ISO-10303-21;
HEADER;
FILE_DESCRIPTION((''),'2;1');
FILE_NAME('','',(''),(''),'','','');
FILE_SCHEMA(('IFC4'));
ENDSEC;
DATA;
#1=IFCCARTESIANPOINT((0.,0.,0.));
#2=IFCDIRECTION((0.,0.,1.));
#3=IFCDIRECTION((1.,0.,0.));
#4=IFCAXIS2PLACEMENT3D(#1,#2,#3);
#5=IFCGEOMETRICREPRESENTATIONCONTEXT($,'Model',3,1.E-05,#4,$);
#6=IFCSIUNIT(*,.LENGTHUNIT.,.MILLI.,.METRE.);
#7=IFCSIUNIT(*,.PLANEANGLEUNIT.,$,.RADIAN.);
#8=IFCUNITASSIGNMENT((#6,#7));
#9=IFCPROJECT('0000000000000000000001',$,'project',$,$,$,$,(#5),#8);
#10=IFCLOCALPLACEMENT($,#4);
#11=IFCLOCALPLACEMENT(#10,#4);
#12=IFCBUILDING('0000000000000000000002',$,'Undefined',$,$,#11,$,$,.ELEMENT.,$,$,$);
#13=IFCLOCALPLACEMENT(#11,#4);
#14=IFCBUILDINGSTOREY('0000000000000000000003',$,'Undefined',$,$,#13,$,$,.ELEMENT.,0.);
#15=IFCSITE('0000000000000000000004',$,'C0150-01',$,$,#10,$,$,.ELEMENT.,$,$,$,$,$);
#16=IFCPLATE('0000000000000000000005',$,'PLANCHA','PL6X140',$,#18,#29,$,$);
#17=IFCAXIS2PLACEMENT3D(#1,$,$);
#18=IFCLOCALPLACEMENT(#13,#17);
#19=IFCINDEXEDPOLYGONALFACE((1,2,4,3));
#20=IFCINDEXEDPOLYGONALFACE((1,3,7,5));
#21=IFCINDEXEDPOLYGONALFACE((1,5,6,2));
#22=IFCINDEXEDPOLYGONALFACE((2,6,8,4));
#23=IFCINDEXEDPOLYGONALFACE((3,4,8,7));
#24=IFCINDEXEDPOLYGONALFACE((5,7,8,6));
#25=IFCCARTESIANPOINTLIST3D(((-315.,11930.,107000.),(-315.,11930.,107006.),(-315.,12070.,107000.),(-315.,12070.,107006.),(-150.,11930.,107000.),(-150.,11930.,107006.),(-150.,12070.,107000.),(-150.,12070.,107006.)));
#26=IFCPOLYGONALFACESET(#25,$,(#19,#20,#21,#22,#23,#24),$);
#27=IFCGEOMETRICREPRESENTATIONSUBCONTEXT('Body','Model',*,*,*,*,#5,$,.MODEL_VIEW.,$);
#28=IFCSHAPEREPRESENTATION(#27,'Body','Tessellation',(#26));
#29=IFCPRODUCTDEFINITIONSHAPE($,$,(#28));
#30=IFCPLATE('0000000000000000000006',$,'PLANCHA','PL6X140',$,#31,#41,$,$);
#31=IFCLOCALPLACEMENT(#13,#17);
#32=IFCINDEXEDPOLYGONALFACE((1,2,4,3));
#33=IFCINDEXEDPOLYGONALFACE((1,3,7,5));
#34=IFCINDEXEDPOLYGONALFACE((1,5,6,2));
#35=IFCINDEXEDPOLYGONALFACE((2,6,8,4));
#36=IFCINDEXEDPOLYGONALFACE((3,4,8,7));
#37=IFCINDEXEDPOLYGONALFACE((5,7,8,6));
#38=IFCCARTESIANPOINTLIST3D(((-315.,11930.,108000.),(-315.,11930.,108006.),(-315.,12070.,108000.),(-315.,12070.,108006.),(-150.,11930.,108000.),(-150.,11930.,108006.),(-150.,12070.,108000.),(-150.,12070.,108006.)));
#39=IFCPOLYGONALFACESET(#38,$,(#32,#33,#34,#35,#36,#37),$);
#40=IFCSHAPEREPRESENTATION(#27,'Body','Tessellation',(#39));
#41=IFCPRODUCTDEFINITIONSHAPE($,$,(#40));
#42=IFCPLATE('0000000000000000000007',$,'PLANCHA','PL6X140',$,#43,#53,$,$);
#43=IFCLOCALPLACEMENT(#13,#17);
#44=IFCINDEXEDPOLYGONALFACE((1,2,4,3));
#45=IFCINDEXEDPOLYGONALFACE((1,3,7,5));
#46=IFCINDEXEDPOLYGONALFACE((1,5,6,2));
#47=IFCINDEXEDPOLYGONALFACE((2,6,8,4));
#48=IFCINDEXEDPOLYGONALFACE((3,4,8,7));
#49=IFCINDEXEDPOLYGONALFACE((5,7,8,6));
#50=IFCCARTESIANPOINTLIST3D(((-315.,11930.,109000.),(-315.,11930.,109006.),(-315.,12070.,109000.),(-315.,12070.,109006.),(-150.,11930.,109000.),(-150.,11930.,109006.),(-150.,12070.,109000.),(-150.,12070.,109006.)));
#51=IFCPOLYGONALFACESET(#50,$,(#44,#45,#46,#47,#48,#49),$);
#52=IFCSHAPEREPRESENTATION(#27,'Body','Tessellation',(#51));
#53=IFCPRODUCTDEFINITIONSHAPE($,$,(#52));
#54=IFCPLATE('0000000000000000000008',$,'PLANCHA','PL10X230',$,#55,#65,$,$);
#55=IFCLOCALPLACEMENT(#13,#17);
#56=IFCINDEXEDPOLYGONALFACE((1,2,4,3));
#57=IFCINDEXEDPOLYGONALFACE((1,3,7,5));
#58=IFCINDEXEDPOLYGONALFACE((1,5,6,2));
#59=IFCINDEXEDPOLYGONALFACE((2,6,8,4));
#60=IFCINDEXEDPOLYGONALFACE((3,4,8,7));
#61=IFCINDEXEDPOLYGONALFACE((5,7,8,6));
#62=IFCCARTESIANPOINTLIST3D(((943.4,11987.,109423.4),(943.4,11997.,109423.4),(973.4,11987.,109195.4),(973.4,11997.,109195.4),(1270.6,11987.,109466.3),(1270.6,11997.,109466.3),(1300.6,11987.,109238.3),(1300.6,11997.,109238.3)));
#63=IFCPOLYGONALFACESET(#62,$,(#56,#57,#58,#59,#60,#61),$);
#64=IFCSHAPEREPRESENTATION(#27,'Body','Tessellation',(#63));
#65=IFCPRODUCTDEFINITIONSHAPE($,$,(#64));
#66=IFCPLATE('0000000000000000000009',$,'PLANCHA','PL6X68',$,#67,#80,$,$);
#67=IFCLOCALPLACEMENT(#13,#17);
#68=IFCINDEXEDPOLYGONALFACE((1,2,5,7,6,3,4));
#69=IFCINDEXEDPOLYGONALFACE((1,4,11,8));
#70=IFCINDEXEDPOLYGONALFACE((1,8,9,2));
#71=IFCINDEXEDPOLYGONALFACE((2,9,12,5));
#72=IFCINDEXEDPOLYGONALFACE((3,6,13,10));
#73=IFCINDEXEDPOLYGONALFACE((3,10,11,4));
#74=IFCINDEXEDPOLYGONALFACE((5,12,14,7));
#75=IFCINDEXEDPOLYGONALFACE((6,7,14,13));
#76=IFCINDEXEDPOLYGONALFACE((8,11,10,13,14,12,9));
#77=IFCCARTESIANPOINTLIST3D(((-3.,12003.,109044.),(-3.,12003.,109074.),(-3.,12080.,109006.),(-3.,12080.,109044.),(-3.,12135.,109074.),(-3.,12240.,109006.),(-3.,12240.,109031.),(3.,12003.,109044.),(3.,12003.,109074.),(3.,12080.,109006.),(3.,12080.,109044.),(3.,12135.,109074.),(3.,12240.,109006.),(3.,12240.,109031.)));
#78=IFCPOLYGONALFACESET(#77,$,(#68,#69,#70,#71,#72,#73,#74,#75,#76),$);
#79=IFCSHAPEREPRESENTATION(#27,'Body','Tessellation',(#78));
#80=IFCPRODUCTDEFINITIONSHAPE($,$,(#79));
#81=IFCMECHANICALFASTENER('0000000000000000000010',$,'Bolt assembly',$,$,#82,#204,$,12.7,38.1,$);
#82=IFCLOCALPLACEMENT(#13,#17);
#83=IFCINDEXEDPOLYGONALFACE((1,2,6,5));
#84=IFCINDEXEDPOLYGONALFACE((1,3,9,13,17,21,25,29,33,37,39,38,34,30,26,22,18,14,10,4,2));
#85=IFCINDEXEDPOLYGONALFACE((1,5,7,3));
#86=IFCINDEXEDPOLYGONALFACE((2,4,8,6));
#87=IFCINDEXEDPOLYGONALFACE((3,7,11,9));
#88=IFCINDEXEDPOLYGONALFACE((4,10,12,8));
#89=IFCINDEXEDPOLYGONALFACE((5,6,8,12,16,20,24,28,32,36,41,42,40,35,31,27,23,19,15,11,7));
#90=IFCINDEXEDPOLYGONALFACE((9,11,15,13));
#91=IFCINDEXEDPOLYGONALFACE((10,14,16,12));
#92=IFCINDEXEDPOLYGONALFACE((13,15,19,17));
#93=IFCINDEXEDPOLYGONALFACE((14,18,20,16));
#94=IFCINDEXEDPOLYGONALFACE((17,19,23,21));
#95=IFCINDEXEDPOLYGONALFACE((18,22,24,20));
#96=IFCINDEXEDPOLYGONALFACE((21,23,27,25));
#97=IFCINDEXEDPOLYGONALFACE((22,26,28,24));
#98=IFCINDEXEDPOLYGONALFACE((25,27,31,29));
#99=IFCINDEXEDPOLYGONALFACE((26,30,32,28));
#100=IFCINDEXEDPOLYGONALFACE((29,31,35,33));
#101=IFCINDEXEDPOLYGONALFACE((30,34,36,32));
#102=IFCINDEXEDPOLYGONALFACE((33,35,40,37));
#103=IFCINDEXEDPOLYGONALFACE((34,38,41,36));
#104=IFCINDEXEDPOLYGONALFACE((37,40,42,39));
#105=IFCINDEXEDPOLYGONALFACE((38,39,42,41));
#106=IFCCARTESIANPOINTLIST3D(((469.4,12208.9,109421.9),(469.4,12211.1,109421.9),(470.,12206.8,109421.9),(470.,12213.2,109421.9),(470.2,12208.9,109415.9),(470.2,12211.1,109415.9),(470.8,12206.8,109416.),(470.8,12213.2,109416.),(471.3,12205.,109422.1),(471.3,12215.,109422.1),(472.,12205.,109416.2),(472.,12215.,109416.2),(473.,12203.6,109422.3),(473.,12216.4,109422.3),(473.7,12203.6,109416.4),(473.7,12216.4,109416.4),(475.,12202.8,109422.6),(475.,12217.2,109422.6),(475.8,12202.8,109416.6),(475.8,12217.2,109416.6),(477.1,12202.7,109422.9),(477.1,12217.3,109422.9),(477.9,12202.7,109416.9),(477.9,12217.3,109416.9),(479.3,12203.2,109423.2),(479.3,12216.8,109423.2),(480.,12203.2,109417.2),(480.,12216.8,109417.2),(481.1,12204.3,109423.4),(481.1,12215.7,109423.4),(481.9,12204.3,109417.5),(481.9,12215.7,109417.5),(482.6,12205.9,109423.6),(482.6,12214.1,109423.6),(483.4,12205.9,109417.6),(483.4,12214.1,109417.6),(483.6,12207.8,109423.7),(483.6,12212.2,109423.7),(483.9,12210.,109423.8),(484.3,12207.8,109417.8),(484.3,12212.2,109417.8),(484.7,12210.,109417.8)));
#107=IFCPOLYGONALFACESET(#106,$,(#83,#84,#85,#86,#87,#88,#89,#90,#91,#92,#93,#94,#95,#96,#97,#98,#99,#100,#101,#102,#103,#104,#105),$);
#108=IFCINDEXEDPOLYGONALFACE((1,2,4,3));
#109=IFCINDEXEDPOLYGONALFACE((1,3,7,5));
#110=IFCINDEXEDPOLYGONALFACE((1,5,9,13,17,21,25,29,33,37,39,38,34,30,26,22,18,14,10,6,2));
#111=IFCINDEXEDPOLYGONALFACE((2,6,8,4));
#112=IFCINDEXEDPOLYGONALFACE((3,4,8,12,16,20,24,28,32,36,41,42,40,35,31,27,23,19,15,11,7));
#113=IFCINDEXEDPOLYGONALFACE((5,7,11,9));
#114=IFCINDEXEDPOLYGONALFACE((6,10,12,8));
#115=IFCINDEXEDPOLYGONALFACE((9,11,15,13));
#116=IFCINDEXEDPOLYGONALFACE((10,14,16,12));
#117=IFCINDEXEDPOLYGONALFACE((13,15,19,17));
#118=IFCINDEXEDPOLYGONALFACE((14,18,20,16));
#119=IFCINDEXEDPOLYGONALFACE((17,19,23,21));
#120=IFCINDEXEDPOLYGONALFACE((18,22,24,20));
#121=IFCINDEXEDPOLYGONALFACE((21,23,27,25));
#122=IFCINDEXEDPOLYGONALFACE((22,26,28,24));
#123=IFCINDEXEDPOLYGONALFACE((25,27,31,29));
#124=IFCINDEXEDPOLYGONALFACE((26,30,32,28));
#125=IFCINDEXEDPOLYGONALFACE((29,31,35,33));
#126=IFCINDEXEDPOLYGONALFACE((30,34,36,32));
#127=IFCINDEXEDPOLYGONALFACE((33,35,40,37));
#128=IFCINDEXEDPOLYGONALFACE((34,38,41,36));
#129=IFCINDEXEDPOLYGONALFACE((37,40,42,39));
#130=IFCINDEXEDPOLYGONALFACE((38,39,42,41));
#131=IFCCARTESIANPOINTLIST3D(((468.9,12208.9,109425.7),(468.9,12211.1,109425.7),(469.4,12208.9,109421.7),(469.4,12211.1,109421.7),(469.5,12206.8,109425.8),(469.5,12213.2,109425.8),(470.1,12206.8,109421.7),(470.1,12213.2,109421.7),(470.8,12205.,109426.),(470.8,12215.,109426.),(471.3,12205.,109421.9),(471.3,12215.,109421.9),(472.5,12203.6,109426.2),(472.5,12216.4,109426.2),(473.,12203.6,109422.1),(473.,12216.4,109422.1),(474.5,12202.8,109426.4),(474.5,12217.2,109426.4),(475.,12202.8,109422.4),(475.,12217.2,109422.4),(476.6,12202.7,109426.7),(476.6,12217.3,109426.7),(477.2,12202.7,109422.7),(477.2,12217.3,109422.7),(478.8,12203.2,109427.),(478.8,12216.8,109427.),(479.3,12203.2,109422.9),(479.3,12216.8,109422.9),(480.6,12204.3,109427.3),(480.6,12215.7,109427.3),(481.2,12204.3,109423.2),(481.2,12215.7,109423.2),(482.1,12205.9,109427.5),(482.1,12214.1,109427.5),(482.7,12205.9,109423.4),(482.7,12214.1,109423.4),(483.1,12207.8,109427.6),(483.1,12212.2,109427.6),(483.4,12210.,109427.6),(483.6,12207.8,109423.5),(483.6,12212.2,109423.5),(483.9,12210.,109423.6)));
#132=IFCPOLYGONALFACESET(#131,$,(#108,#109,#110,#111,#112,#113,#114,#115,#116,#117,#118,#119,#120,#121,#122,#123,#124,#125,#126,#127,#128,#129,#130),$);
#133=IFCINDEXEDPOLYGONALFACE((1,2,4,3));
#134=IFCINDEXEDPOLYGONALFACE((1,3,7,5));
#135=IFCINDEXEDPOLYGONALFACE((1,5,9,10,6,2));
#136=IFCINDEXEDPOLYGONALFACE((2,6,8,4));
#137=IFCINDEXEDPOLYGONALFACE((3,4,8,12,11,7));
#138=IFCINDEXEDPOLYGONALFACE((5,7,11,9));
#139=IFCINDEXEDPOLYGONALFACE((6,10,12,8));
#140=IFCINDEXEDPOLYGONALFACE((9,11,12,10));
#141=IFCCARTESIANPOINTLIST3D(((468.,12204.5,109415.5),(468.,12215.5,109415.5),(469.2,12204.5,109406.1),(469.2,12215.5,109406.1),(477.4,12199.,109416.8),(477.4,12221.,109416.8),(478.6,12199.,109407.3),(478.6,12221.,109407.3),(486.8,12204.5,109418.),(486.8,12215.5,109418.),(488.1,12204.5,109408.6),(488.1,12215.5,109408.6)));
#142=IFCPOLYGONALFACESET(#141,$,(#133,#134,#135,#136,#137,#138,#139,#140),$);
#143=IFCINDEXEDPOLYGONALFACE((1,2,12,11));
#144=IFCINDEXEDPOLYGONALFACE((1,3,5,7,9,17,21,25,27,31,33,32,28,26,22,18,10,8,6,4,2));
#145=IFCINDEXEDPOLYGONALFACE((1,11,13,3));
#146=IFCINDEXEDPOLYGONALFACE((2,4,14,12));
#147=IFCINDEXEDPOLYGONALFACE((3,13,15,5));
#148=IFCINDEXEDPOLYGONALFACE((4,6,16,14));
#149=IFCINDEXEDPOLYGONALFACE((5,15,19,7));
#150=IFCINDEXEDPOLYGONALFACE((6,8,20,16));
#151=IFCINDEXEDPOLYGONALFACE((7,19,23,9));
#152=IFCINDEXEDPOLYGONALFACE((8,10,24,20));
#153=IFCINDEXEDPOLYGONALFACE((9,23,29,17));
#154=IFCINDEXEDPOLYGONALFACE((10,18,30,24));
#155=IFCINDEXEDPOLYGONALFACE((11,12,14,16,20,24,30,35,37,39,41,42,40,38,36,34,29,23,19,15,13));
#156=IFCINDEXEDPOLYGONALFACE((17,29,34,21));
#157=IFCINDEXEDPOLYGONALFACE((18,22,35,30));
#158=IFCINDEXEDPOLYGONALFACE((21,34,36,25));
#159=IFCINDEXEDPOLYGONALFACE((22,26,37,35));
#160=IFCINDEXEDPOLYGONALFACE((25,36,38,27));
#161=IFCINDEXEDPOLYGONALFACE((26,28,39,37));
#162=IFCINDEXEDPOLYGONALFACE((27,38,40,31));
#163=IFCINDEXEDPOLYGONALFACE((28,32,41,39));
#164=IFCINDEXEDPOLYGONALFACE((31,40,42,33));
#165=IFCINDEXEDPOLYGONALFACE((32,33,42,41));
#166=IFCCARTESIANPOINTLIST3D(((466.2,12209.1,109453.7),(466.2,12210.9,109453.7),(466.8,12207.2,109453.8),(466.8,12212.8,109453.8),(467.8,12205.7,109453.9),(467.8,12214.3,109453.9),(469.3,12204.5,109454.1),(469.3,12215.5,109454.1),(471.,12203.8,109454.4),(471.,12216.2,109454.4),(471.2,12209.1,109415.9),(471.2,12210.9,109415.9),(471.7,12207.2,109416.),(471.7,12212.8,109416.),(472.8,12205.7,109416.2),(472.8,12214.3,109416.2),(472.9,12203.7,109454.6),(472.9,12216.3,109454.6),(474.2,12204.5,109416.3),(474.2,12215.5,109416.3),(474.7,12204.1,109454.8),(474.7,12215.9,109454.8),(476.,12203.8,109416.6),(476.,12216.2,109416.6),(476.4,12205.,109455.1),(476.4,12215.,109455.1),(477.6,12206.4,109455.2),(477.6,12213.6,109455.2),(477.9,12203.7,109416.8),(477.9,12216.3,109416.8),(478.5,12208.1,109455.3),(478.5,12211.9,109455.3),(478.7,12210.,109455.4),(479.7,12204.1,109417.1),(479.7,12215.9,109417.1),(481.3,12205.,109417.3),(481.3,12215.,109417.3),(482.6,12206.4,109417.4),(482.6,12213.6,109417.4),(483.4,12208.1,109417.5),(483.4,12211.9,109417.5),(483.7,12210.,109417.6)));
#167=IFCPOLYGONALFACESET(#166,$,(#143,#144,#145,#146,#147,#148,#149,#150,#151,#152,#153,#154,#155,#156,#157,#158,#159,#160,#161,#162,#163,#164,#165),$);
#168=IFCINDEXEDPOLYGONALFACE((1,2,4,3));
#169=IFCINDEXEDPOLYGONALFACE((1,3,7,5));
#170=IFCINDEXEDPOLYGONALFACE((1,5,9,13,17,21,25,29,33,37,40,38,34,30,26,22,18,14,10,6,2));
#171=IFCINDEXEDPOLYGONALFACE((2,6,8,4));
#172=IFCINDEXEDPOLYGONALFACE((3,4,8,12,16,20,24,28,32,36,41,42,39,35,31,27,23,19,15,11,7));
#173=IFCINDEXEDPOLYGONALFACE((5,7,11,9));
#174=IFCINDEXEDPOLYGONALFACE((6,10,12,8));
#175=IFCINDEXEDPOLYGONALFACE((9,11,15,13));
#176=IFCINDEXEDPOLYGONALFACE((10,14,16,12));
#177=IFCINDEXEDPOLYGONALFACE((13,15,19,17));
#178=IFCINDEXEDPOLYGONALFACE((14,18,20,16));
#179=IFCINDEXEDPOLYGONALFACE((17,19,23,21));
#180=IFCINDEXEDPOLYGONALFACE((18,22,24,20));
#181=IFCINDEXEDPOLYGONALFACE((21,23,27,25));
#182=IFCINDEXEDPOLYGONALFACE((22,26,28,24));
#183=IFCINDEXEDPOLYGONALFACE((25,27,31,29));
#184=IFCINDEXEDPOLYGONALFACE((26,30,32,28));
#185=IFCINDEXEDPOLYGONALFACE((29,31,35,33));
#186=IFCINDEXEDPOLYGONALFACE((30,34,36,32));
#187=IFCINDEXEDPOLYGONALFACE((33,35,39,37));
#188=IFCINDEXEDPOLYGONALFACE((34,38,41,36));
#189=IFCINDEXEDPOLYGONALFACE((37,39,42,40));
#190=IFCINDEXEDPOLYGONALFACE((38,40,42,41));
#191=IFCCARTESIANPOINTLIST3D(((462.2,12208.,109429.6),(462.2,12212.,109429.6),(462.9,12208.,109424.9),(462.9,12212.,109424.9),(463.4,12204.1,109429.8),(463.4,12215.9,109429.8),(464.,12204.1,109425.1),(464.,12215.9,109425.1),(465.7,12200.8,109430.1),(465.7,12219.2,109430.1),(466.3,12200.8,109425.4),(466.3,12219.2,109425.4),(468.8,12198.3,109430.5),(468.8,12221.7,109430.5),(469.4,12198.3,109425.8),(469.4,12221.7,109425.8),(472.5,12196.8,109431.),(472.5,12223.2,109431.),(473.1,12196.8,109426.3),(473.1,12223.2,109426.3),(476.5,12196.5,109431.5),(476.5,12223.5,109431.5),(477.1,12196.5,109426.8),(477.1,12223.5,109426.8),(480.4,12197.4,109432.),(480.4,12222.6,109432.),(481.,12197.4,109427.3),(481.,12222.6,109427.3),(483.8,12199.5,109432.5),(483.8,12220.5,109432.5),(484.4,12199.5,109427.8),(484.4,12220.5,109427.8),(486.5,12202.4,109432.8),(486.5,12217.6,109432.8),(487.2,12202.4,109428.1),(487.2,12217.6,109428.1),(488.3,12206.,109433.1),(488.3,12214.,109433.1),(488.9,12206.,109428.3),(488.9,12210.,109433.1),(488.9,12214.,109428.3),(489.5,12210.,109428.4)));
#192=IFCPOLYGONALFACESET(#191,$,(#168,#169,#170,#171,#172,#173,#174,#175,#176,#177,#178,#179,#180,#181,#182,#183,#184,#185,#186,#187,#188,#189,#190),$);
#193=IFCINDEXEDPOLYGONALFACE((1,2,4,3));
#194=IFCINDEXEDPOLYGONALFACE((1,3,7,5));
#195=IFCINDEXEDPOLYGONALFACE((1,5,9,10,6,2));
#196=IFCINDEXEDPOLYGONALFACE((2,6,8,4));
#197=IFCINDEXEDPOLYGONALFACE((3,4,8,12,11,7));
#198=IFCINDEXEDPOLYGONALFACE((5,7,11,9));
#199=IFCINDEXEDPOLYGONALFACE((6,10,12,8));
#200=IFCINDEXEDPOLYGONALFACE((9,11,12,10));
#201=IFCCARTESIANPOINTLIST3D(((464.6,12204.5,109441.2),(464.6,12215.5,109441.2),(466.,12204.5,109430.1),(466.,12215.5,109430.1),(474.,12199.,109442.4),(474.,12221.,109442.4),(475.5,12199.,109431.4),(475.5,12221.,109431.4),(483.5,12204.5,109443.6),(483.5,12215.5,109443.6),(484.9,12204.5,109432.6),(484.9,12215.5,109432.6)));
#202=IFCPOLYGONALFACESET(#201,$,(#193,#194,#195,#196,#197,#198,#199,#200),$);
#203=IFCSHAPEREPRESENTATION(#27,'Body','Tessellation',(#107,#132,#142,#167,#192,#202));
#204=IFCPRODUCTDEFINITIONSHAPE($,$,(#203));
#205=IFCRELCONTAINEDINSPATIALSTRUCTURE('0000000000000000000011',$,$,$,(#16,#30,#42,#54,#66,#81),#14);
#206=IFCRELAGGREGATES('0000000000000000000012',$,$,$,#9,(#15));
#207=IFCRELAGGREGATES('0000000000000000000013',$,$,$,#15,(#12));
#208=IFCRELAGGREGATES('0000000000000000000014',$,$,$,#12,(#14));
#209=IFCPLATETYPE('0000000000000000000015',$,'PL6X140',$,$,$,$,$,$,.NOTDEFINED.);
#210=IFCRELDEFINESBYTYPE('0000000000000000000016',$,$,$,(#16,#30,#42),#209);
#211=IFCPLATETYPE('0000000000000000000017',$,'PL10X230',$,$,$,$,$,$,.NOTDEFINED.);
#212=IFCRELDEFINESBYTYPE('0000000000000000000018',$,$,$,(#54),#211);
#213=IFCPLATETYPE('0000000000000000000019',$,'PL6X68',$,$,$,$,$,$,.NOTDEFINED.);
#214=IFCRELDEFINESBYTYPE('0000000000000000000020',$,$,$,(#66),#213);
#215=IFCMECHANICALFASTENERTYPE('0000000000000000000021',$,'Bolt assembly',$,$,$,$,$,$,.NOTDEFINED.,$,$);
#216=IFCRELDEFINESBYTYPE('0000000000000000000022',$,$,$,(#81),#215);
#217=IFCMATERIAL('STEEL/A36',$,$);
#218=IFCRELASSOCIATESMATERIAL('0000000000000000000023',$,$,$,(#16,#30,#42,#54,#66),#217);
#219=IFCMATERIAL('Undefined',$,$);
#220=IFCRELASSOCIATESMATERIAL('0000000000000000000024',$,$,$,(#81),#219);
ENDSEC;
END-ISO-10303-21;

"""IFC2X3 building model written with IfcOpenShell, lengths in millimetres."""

from ifc_helpers import new_model, si_unit, frame, origin_with_axes, origin_2d_with_axis, place, context, subcontext, project, spatial, polyline, circle, outline, extrude, source, transform, mapped, material, type_object, element, save


model = new_model("IFC2X3")

# Units and contexts
model_context = context("Model", 3, precision=1e-05, world=origin_with_axes())
body_context = subcontext(model_context, "Body", "Model", "MODEL_VIEW")
ifc_project = project(units=[si_unit("LENGTHUNIT", "METRE", prefix="MILLI"), si_unit("PLANEANGLEUNIT", "RADIAN")], contexts=[model_context])

# Site, building, storey
site_placement = place(None, origin_with_axes())
site = spatial("IfcSite", under=ifc_project, at=site_placement, Name="C0150-01", CompositionType="ELEMENT")
building_placement = place(site_placement, origin_with_axes())
building = spatial("IfcBuilding", under=site, at=building_placement, Name="Undefined", CompositionType="ELEMENT")
storey_placement = place(building_placement, origin_with_axes())
storey = spatial("IfcBuildingStorey", under=building, at=storey_placement, Name="Undefined", CompositionType="ELEMENT", Elevation=0.0)

# Shared definitions
ifc_material_1 = material(Name="STEEL/A36")

# Plates
plate_type_1 = type_object("IfcPlateType", Name="PL6X140", PredefinedType="NOTDEFINED")
for number, where, z_axis, x_axis, name in (
    (1, (-150.0, 12070.0, 107003.0), (-0.000004, 0.0, -1.0), (0.0, -1.0, 0.0), "PLANCHA"),
    (2, (-150.0, 12070.0, 108003.0), (-0.000004, 0.0, -1.0), (0.0, -1.0, 0.0), "PLANCHA"),
    (3, (-150.0, 12070.0, 109003.0), (-0.000004, 0.0, -1.0), (0.0, -1.0, 0.0), "PLANCHA"),
):
    element("IfcPlate", number, at=place(storey_placement, frame(where, z_axis=z_axis, x_axis=x_axis)), inside=storey, type_object=plate_type_1, material=ifc_material_1, Name=name, Description="PL6X140", context=body_context, shape_type="SweptSolid", body=[
        extrude(outline(polyline([(0.0, 0.0), (140.0, 0.0), (140.0, 165.0), (0.0, 165.0), (0.0, 0.0)])), frame((0.0, 0.0, -3.0), z_axis=(0.0, 0.0, 1.0), x_axis=(1.0, 0.0, 0.0)), (0.0, 0.0, 1.0), 6.0),
    ])
plate_type_2 = type_object("IfcPlateType", Name="PL10X230", PredefinedType="NOTDEFINED")
plate_1_placement = place(storey_placement, frame((943.4, 11992.0, 109423.4), z_axis=(0.0, -1.0, 0.0), x_axis=(0.130054, 0.0, -0.991507)))
element("IfcPlate", 4, at=plate_1_placement, inside=storey, type_object=plate_type_2, material=ifc_material_1, Name="PLANCHA", Description="PL10X230", context=body_context, shape_type="SweptSolid", body=[
    extrude(outline(polyline([(0.0, 0.0), (230.0, 0.0), (230.0, 330.0), (0.0, 330.0), (0.0, 0.0)])), frame((0.0, 0.0, -5.0), z_axis=(0.0, 0.0, 1.0), x_axis=(1.0, 0.0, 0.0)), (0.0, 0.0, 1.0), 10.0),
])
plate_type_3 = type_object("IfcPlateType", Name="PL6X68", PredefinedType="NOTDEFINED")
plate_2_placement = place(storey_placement, frame((0.0, 12240.0, 109006.0), z_axis=(1.0, 0.0, 0.0), x_axis=(0.0, -0.000005, 1.0)))
element("IfcPlate", 5, at=plate_2_placement, inside=storey, type_object=plate_type_3, material=ifc_material_1, Name="PLANCHA", Description="PL6X68", context=body_context, shape_type="SweptSolid", body=[
    extrude(outline(polyline([(0.0, 0.0), (25.0, 0.0), (68.0, 105.0), (68.0, 237.0), (38.0, 237.0), (38.0, 160.0), (0.0, 160.0), (0.0, 0.0)])), frame((0.0, 0.0, -3.0), z_axis=(0.0, 0.0, 1.0), x_axis=(1.0, 0.0, 0.0)), (0.0, 0.0, 1.0), 6.0),
])

# Mechanical fastener
ifc_material_2 = material(Name="Undefined")
mechanical_fastener_type = type_object("IfcMechanicalFastenerType", Name="Bolt assembly")
shared_shape_1 = source(origin_with_axes(), body_context, "Body", "SweptSolid", [
    extrude(circle(Radius=7.3, at=origin_2d_with_axis()), frame((0.0, -9.9, 0.0), z_axis=(0.0, 1.0, 0.0), x_axis=(1.0, 0.0, 0.0)), (0.0, 0.0, 1.0), 6.0),
    extrude(circle(Radius=7.3, at=origin_2d_with_axis()), frame((0.0, -4.1, 0.0), z_axis=(0.0, 1.0, 0.0), x_axis=(1.0, 0.0, 0.0)), (0.0, 0.0, 1.0), 4.1),
    extrude(outline(polyline([(9.5, -5.5), (9.5, 5.5), (0.0, 11.0), (-9.5, 5.5), (-9.5, -5.5), (0.0, -11.0), (9.5, -5.5)])), frame((0.0, -19.5, 0.0), z_axis=(0.0, 1.0, 0.0), x_axis=(1.0, 0.0, 0.0)), (0.0, 0.0, 1.0), 9.5),
    extrude(circle(Radius=6.3, at=origin_2d_with_axis()), frame((0.0, -10.0, 0.0), z_axis=(0.0, 1.0, 0.0), x_axis=(1.0, 0.0, 0.0)), (0.0, 0.0, 1.0), 38.1),
    extrude(circle(Radius=13.5, at=origin_2d_with_axis()), frame((0.0, 0.0, 0.0), z_axis=(0.0, 1.0, 0.0), x_axis=(1.0, 0.0, 0.0)), (0.0, 0.0, 1.0), 4.8),
    extrude(outline(polyline([(9.5, -5.5), (9.5, 5.5), (0.0, 11.0), (-9.5, 5.5), (-9.5, -5.5), (0.0, -11.0), (9.5, -5.5)])), frame((0.0, 4.8, 0.0), z_axis=(0.0, 1.0, 0.0), x_axis=(1.0, 0.0, 0.0)), (0.0, 0.0, 1.0), 11.1),
])
mechanical_fastener_1_placement = place(storey_placement, frame((476.1, 12210.0, 109426.7), z_axis=(0.0, -1.0, 0.0), x_axis=(0.991507, 0.0, 0.130054)))
element("IfcMechanicalFastener", 6, at=mechanical_fastener_1_placement, inside=storey, type_object=mechanical_fastener_type, material=ifc_material_2, Name="Bolt assembly", NominalDiameter=12.7, NominalLength=38.1, context=body_context, shape_type="MappedRepresentation", body=[
    mapped(shared_shape_1, transform((0.0, 0.0, 0.0))),
])

save(model, "model.ifc")
